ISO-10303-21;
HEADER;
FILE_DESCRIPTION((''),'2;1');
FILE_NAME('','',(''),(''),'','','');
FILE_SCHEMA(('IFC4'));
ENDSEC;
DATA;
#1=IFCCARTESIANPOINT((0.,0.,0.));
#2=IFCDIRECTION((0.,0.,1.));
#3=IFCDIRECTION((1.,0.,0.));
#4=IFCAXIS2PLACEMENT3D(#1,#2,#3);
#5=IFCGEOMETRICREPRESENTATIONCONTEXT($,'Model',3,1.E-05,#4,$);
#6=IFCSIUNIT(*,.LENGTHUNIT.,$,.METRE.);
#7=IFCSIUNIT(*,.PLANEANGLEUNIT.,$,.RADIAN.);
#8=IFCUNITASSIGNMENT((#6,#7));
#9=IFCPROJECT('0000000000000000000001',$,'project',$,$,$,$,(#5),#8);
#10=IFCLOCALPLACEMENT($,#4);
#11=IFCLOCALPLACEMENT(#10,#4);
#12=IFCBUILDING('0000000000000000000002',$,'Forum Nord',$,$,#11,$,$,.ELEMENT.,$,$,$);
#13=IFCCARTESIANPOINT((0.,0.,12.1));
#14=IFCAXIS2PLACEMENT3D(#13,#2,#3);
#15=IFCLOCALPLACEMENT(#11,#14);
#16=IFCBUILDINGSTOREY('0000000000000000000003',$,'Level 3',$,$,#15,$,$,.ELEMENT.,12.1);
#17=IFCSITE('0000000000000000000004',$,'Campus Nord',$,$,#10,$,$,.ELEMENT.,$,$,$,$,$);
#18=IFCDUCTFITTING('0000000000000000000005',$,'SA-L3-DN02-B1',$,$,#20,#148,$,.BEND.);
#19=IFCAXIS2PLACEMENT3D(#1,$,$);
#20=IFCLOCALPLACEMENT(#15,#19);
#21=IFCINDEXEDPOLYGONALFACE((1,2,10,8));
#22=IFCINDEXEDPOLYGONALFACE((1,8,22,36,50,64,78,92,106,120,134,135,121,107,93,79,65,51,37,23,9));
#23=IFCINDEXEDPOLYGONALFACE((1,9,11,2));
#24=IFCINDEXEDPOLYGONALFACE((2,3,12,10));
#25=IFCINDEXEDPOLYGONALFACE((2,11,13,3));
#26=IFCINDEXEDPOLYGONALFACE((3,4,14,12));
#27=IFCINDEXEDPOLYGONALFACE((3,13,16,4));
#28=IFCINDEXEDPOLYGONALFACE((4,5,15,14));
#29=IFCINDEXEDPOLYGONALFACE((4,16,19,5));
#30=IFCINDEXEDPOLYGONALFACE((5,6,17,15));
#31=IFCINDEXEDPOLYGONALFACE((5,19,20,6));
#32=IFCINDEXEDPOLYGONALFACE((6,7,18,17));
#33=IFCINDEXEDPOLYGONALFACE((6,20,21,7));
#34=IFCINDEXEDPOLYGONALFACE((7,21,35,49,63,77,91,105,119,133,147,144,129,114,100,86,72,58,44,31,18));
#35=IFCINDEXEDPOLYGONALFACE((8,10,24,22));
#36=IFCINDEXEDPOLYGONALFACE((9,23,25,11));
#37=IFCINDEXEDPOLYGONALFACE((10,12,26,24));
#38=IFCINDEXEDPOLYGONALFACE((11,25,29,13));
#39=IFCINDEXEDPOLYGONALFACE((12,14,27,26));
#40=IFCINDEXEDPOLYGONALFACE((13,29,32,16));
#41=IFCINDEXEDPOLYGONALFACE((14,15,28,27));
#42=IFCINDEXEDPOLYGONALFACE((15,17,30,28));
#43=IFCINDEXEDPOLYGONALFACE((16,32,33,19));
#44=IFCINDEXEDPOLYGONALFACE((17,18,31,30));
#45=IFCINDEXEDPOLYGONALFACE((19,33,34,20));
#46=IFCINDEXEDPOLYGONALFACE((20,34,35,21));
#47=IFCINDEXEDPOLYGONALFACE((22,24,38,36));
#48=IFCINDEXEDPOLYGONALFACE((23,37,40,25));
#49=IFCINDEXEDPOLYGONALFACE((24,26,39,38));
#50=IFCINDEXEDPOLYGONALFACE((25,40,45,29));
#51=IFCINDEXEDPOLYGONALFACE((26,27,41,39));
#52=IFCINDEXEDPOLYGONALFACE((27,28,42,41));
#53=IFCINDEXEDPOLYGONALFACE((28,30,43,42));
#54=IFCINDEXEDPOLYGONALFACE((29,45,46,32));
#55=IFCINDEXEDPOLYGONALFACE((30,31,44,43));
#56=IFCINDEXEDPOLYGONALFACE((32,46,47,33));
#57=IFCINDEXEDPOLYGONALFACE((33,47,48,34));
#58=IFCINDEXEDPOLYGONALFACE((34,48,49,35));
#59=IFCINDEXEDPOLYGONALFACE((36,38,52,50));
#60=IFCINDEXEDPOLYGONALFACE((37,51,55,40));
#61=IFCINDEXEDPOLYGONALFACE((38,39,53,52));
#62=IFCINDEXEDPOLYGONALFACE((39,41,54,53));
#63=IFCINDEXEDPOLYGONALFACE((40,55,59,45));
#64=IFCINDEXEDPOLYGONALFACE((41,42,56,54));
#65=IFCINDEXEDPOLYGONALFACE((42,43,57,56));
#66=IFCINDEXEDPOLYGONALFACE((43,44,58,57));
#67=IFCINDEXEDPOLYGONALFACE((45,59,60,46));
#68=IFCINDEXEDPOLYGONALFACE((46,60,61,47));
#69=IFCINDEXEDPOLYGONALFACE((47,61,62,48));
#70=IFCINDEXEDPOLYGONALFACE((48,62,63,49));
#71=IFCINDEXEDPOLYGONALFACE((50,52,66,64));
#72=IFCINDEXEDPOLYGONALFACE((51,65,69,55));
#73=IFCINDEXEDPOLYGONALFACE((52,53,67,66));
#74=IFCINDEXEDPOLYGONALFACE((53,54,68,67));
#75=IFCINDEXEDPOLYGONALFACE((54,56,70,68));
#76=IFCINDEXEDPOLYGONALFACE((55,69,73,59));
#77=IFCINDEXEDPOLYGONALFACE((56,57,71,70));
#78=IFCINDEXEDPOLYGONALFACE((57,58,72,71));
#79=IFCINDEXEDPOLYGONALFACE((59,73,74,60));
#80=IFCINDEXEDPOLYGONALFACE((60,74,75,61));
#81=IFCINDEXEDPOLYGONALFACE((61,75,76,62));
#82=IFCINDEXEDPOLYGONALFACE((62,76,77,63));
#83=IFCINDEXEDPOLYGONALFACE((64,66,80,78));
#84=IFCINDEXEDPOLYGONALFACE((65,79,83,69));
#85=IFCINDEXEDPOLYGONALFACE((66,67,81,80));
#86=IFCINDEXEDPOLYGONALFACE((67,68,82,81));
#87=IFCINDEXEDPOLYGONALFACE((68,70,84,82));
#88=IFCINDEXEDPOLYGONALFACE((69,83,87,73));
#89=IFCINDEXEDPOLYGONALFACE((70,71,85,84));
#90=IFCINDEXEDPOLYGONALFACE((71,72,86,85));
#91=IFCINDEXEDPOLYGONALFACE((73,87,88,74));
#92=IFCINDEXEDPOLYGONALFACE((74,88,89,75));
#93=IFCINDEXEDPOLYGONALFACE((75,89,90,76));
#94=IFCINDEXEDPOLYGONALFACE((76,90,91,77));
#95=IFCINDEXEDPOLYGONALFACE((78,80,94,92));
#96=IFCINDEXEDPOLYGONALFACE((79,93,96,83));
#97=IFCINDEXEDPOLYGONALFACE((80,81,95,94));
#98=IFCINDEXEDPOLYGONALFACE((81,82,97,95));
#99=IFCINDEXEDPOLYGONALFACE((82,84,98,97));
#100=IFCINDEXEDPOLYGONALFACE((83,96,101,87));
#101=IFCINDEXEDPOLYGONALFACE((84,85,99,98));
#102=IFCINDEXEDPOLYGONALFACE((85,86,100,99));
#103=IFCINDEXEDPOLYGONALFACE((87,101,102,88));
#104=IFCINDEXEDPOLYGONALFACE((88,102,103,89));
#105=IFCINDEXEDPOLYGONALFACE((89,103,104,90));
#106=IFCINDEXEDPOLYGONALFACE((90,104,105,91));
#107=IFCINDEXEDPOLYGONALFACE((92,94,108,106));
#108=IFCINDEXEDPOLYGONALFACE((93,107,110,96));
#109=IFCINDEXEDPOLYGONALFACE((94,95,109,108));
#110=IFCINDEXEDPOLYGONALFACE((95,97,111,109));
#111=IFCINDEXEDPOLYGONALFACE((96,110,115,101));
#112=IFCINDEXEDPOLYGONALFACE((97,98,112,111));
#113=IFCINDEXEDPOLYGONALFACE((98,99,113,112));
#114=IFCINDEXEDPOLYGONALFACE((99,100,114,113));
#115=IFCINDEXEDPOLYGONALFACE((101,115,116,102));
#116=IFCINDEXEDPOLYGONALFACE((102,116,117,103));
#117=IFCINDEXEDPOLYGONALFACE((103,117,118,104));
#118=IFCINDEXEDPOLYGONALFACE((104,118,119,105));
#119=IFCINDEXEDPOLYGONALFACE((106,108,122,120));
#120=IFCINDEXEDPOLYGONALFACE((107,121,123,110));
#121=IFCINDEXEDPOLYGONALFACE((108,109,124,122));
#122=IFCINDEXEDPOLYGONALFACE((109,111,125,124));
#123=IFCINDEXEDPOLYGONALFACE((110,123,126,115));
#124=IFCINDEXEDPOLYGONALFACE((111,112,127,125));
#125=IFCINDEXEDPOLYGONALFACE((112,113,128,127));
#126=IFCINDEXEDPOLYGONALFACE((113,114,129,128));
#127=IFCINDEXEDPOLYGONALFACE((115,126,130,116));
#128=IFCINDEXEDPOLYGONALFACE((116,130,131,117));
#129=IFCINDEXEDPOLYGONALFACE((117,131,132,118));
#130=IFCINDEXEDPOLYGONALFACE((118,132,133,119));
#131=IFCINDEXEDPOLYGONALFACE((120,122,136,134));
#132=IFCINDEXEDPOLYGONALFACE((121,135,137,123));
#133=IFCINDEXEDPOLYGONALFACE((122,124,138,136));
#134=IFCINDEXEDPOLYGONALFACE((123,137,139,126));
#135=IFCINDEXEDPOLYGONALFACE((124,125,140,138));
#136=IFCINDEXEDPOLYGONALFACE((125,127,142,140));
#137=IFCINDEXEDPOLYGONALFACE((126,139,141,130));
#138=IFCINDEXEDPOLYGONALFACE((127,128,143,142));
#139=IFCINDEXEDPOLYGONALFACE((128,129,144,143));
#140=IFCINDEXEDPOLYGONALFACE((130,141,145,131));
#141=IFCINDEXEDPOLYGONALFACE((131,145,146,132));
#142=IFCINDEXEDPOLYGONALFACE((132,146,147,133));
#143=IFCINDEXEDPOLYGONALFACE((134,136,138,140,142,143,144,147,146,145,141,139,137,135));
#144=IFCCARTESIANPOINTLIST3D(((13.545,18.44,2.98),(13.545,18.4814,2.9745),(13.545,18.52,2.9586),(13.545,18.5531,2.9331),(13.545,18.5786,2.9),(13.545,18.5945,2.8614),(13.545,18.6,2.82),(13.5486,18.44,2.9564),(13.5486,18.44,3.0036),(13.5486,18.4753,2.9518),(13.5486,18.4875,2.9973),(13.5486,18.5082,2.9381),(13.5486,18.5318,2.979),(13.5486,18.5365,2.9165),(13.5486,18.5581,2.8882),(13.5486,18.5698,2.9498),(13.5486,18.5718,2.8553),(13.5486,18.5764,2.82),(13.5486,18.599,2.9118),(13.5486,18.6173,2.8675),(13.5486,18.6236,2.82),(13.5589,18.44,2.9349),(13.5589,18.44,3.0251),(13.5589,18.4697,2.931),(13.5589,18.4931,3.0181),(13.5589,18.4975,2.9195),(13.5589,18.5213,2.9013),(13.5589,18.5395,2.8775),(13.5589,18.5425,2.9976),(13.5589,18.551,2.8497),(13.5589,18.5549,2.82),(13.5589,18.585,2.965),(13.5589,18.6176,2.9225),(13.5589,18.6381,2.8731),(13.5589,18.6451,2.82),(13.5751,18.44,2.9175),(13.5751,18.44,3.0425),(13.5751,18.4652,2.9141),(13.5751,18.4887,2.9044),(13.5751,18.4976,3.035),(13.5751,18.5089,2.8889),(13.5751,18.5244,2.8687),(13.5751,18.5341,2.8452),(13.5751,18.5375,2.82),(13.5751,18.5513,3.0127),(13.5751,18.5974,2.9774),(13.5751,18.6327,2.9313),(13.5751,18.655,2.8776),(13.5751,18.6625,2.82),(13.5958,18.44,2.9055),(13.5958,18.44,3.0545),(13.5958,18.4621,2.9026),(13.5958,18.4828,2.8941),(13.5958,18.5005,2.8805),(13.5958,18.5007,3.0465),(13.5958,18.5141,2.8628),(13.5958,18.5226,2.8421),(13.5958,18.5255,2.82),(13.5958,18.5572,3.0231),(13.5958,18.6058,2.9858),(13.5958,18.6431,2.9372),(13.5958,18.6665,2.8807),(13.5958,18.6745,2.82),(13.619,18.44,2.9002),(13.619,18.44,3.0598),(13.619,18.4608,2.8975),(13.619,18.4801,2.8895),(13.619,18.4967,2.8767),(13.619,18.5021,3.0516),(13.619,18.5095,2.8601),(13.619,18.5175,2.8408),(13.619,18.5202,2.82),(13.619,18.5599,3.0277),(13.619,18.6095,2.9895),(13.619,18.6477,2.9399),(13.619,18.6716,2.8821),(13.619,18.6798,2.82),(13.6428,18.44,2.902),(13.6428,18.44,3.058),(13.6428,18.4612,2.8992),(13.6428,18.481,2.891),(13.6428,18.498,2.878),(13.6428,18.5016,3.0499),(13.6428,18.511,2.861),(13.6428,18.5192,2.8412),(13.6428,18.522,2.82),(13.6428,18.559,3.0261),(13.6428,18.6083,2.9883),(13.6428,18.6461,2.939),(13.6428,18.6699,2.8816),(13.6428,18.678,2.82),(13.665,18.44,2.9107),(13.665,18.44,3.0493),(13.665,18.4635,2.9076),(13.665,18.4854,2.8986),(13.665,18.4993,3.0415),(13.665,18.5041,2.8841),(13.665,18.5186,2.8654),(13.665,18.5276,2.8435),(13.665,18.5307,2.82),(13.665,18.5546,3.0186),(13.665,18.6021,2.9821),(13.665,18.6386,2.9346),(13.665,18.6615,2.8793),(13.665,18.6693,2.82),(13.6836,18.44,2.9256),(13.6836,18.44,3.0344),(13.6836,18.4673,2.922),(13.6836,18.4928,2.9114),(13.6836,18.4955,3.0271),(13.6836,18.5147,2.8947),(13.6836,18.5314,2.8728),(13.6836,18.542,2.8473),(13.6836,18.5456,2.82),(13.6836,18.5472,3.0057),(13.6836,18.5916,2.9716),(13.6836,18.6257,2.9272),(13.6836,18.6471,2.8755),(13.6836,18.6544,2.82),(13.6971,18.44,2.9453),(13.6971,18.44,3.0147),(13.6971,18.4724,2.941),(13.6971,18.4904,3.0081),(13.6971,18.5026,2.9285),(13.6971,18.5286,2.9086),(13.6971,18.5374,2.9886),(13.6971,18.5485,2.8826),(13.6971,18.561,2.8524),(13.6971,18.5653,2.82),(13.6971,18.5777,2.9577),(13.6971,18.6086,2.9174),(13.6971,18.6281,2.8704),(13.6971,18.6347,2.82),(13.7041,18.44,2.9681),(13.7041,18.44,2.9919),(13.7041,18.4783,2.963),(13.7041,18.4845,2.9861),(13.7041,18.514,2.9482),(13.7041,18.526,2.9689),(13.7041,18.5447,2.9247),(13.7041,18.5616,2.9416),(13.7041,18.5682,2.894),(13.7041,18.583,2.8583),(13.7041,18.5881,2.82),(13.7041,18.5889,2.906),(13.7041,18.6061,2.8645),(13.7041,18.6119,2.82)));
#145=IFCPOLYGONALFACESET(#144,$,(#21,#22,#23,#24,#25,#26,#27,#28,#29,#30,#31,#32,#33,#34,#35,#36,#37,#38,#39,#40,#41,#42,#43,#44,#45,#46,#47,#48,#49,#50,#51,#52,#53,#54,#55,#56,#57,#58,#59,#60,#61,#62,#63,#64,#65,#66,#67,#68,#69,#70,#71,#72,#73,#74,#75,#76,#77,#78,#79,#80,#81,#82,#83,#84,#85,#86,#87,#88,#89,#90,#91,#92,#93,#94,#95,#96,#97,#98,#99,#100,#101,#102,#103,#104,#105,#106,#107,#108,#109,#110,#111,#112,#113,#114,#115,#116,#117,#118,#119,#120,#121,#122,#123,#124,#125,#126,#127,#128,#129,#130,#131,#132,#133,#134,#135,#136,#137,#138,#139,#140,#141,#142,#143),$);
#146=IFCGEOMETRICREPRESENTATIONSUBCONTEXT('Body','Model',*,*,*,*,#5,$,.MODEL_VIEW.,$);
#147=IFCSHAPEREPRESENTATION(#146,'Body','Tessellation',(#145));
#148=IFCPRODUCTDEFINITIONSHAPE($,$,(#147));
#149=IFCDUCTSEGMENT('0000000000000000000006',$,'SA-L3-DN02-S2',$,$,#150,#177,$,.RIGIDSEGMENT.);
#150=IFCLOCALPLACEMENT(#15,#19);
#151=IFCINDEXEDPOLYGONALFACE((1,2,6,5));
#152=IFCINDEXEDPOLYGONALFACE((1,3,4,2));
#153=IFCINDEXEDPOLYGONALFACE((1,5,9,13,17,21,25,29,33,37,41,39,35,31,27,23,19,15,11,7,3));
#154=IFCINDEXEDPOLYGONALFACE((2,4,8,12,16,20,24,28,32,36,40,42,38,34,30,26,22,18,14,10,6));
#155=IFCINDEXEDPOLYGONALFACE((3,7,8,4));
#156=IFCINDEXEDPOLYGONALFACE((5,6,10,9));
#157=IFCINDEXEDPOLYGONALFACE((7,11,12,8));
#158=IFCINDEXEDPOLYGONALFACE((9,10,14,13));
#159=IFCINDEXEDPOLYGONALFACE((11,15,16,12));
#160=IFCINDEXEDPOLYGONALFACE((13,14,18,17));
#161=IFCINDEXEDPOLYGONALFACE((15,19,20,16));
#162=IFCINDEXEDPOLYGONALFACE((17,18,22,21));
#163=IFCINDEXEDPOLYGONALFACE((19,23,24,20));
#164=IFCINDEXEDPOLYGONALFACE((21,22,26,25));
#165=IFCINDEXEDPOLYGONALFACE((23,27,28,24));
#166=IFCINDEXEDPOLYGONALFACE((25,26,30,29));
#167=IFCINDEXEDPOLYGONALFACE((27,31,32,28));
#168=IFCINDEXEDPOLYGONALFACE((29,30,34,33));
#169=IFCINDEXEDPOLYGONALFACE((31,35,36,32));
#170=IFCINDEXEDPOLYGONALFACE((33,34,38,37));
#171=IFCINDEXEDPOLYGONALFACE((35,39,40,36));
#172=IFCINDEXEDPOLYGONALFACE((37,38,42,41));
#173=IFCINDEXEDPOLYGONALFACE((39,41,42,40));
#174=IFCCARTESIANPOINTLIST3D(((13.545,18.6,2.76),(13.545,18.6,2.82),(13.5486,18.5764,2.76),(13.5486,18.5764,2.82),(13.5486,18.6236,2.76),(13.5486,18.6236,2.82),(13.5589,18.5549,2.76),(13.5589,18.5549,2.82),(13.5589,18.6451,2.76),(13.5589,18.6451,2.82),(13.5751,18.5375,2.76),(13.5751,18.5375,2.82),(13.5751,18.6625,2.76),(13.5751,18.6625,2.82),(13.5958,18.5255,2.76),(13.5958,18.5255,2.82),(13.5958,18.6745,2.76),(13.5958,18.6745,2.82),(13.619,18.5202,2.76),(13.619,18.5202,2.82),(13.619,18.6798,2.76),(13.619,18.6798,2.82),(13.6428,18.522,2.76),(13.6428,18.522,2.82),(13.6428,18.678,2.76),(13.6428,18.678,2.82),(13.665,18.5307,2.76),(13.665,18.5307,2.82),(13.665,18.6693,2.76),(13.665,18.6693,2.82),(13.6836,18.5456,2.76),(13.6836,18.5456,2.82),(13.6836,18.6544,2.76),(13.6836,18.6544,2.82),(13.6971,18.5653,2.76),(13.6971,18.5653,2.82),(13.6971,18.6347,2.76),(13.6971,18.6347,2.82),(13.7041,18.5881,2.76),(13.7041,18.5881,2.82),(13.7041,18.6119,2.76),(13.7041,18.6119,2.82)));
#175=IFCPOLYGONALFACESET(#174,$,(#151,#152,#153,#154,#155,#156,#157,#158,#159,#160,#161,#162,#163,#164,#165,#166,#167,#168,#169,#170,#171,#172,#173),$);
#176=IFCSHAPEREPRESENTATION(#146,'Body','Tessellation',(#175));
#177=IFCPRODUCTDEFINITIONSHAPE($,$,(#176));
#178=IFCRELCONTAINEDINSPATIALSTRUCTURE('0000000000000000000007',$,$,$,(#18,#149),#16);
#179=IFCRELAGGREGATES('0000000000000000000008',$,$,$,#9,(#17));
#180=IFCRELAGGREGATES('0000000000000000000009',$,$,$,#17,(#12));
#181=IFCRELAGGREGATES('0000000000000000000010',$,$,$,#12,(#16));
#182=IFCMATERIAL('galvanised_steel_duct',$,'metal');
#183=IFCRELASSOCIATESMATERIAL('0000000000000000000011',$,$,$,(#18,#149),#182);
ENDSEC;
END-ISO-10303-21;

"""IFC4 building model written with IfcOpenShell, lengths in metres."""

from ifc_helpers import new_model, entity, si_unit, frame, origin_with_axes, origin_2d_with_axis, place, context, subcontext, project, spatial, circle, extrude, material, element, save


model = new_model("IFC4")

# Units and contexts
model_context = context("Model", 3, precision=1e-05, world=origin_with_axes())
body_context = subcontext(model_context, "Body", "Model", "MODEL_VIEW")
ifc_project = project(units=[si_unit("LENGTHUNIT", "METRE"), si_unit("PLANEANGLEUNIT", "RADIAN")], contexts=[model_context])

# Site, building, storey
site_placement = place(None, origin_with_axes())
site = spatial("IfcSite", under=ifc_project, at=site_placement, Name="Campus Nord", CompositionType="ELEMENT")
building_placement = place(site_placement, origin_with_axes())
building = spatial("IfcBuilding", under=site, at=building_placement, Name="Forum Nord", CompositionType="ELEMENT")
storey_placement = place(building_placement, frame((0.0, 0.0, 12.1), z_axis=(0.0, 0.0, 1.0), x_axis=(1.0, 0.0, 0.0)))
storey = spatial("IfcBuildingStorey", under=building, at=storey_placement, Name="Level 3", CompositionType="ELEMENT", Elevation=12.1)

# Duct fitting
ifc_material_1 = material(Name="galvanised_steel_duct", Category="metal")
duct_fitting_1_placement = place(storey_placement, frame((13.625, 18.44, 2.98), z_axis=(0.0, 1.0, 0.0), x_axis=(-1.0, 0.0, 0.0)))
ifc_direction_1 = entity("IfcDirection", [1.0, 0.0, 0.0])
element("IfcDuctFitting", 1, at=duct_fitting_1_placement, inside=storey, material=ifc_material_1, Name="SA-L3-DN02-B1", PredefinedType="BEND", context=body_context, shape_type="SweptSolid", body=[
    entity("IfcRevolvedAreaSolid", entity("IfcCircleProfileDef", "AREA", None, entity("IfcAxis2Placement2D", entity("IfcCartesianPoint", [0.0, 0.0]), entity("IfcDirection", [1.0, 0.0])), 0.08), entity("IfcAxis2Placement3D", entity("IfcCartesianPoint", [0.0, 0.0, 0.0]), entity("IfcDirection", [0.0, 0.0, 1.0]), ifc_direction_1), entity("IfcAxis1Placement", entity("IfcCartesianPoint", [0.0, -0.16, 0.0]), ifc_direction_1), 1.5708),
])

# Duct segment
duct_segment_1_placement = place(storey_placement, frame((13.625, 18.6, 2.82), z_axis=(0.0, 0.0, -1.0), x_axis=(-1.0, 0.0, 0.0)))
element("IfcDuctSegment", 2, at=duct_segment_1_placement, inside=storey, material=ifc_material_1, Name="SA-L3-DN02-S2", PredefinedType="RIGIDSEGMENT", context=body_context, shape_type="SweptSolid", body=[
    extrude(circle(Radius=0.08, at=origin_2d_with_axis()), origin_with_axes(), (0.0, 0.0, 1.0), 0.06),
])

save(model, "model.ifc")
